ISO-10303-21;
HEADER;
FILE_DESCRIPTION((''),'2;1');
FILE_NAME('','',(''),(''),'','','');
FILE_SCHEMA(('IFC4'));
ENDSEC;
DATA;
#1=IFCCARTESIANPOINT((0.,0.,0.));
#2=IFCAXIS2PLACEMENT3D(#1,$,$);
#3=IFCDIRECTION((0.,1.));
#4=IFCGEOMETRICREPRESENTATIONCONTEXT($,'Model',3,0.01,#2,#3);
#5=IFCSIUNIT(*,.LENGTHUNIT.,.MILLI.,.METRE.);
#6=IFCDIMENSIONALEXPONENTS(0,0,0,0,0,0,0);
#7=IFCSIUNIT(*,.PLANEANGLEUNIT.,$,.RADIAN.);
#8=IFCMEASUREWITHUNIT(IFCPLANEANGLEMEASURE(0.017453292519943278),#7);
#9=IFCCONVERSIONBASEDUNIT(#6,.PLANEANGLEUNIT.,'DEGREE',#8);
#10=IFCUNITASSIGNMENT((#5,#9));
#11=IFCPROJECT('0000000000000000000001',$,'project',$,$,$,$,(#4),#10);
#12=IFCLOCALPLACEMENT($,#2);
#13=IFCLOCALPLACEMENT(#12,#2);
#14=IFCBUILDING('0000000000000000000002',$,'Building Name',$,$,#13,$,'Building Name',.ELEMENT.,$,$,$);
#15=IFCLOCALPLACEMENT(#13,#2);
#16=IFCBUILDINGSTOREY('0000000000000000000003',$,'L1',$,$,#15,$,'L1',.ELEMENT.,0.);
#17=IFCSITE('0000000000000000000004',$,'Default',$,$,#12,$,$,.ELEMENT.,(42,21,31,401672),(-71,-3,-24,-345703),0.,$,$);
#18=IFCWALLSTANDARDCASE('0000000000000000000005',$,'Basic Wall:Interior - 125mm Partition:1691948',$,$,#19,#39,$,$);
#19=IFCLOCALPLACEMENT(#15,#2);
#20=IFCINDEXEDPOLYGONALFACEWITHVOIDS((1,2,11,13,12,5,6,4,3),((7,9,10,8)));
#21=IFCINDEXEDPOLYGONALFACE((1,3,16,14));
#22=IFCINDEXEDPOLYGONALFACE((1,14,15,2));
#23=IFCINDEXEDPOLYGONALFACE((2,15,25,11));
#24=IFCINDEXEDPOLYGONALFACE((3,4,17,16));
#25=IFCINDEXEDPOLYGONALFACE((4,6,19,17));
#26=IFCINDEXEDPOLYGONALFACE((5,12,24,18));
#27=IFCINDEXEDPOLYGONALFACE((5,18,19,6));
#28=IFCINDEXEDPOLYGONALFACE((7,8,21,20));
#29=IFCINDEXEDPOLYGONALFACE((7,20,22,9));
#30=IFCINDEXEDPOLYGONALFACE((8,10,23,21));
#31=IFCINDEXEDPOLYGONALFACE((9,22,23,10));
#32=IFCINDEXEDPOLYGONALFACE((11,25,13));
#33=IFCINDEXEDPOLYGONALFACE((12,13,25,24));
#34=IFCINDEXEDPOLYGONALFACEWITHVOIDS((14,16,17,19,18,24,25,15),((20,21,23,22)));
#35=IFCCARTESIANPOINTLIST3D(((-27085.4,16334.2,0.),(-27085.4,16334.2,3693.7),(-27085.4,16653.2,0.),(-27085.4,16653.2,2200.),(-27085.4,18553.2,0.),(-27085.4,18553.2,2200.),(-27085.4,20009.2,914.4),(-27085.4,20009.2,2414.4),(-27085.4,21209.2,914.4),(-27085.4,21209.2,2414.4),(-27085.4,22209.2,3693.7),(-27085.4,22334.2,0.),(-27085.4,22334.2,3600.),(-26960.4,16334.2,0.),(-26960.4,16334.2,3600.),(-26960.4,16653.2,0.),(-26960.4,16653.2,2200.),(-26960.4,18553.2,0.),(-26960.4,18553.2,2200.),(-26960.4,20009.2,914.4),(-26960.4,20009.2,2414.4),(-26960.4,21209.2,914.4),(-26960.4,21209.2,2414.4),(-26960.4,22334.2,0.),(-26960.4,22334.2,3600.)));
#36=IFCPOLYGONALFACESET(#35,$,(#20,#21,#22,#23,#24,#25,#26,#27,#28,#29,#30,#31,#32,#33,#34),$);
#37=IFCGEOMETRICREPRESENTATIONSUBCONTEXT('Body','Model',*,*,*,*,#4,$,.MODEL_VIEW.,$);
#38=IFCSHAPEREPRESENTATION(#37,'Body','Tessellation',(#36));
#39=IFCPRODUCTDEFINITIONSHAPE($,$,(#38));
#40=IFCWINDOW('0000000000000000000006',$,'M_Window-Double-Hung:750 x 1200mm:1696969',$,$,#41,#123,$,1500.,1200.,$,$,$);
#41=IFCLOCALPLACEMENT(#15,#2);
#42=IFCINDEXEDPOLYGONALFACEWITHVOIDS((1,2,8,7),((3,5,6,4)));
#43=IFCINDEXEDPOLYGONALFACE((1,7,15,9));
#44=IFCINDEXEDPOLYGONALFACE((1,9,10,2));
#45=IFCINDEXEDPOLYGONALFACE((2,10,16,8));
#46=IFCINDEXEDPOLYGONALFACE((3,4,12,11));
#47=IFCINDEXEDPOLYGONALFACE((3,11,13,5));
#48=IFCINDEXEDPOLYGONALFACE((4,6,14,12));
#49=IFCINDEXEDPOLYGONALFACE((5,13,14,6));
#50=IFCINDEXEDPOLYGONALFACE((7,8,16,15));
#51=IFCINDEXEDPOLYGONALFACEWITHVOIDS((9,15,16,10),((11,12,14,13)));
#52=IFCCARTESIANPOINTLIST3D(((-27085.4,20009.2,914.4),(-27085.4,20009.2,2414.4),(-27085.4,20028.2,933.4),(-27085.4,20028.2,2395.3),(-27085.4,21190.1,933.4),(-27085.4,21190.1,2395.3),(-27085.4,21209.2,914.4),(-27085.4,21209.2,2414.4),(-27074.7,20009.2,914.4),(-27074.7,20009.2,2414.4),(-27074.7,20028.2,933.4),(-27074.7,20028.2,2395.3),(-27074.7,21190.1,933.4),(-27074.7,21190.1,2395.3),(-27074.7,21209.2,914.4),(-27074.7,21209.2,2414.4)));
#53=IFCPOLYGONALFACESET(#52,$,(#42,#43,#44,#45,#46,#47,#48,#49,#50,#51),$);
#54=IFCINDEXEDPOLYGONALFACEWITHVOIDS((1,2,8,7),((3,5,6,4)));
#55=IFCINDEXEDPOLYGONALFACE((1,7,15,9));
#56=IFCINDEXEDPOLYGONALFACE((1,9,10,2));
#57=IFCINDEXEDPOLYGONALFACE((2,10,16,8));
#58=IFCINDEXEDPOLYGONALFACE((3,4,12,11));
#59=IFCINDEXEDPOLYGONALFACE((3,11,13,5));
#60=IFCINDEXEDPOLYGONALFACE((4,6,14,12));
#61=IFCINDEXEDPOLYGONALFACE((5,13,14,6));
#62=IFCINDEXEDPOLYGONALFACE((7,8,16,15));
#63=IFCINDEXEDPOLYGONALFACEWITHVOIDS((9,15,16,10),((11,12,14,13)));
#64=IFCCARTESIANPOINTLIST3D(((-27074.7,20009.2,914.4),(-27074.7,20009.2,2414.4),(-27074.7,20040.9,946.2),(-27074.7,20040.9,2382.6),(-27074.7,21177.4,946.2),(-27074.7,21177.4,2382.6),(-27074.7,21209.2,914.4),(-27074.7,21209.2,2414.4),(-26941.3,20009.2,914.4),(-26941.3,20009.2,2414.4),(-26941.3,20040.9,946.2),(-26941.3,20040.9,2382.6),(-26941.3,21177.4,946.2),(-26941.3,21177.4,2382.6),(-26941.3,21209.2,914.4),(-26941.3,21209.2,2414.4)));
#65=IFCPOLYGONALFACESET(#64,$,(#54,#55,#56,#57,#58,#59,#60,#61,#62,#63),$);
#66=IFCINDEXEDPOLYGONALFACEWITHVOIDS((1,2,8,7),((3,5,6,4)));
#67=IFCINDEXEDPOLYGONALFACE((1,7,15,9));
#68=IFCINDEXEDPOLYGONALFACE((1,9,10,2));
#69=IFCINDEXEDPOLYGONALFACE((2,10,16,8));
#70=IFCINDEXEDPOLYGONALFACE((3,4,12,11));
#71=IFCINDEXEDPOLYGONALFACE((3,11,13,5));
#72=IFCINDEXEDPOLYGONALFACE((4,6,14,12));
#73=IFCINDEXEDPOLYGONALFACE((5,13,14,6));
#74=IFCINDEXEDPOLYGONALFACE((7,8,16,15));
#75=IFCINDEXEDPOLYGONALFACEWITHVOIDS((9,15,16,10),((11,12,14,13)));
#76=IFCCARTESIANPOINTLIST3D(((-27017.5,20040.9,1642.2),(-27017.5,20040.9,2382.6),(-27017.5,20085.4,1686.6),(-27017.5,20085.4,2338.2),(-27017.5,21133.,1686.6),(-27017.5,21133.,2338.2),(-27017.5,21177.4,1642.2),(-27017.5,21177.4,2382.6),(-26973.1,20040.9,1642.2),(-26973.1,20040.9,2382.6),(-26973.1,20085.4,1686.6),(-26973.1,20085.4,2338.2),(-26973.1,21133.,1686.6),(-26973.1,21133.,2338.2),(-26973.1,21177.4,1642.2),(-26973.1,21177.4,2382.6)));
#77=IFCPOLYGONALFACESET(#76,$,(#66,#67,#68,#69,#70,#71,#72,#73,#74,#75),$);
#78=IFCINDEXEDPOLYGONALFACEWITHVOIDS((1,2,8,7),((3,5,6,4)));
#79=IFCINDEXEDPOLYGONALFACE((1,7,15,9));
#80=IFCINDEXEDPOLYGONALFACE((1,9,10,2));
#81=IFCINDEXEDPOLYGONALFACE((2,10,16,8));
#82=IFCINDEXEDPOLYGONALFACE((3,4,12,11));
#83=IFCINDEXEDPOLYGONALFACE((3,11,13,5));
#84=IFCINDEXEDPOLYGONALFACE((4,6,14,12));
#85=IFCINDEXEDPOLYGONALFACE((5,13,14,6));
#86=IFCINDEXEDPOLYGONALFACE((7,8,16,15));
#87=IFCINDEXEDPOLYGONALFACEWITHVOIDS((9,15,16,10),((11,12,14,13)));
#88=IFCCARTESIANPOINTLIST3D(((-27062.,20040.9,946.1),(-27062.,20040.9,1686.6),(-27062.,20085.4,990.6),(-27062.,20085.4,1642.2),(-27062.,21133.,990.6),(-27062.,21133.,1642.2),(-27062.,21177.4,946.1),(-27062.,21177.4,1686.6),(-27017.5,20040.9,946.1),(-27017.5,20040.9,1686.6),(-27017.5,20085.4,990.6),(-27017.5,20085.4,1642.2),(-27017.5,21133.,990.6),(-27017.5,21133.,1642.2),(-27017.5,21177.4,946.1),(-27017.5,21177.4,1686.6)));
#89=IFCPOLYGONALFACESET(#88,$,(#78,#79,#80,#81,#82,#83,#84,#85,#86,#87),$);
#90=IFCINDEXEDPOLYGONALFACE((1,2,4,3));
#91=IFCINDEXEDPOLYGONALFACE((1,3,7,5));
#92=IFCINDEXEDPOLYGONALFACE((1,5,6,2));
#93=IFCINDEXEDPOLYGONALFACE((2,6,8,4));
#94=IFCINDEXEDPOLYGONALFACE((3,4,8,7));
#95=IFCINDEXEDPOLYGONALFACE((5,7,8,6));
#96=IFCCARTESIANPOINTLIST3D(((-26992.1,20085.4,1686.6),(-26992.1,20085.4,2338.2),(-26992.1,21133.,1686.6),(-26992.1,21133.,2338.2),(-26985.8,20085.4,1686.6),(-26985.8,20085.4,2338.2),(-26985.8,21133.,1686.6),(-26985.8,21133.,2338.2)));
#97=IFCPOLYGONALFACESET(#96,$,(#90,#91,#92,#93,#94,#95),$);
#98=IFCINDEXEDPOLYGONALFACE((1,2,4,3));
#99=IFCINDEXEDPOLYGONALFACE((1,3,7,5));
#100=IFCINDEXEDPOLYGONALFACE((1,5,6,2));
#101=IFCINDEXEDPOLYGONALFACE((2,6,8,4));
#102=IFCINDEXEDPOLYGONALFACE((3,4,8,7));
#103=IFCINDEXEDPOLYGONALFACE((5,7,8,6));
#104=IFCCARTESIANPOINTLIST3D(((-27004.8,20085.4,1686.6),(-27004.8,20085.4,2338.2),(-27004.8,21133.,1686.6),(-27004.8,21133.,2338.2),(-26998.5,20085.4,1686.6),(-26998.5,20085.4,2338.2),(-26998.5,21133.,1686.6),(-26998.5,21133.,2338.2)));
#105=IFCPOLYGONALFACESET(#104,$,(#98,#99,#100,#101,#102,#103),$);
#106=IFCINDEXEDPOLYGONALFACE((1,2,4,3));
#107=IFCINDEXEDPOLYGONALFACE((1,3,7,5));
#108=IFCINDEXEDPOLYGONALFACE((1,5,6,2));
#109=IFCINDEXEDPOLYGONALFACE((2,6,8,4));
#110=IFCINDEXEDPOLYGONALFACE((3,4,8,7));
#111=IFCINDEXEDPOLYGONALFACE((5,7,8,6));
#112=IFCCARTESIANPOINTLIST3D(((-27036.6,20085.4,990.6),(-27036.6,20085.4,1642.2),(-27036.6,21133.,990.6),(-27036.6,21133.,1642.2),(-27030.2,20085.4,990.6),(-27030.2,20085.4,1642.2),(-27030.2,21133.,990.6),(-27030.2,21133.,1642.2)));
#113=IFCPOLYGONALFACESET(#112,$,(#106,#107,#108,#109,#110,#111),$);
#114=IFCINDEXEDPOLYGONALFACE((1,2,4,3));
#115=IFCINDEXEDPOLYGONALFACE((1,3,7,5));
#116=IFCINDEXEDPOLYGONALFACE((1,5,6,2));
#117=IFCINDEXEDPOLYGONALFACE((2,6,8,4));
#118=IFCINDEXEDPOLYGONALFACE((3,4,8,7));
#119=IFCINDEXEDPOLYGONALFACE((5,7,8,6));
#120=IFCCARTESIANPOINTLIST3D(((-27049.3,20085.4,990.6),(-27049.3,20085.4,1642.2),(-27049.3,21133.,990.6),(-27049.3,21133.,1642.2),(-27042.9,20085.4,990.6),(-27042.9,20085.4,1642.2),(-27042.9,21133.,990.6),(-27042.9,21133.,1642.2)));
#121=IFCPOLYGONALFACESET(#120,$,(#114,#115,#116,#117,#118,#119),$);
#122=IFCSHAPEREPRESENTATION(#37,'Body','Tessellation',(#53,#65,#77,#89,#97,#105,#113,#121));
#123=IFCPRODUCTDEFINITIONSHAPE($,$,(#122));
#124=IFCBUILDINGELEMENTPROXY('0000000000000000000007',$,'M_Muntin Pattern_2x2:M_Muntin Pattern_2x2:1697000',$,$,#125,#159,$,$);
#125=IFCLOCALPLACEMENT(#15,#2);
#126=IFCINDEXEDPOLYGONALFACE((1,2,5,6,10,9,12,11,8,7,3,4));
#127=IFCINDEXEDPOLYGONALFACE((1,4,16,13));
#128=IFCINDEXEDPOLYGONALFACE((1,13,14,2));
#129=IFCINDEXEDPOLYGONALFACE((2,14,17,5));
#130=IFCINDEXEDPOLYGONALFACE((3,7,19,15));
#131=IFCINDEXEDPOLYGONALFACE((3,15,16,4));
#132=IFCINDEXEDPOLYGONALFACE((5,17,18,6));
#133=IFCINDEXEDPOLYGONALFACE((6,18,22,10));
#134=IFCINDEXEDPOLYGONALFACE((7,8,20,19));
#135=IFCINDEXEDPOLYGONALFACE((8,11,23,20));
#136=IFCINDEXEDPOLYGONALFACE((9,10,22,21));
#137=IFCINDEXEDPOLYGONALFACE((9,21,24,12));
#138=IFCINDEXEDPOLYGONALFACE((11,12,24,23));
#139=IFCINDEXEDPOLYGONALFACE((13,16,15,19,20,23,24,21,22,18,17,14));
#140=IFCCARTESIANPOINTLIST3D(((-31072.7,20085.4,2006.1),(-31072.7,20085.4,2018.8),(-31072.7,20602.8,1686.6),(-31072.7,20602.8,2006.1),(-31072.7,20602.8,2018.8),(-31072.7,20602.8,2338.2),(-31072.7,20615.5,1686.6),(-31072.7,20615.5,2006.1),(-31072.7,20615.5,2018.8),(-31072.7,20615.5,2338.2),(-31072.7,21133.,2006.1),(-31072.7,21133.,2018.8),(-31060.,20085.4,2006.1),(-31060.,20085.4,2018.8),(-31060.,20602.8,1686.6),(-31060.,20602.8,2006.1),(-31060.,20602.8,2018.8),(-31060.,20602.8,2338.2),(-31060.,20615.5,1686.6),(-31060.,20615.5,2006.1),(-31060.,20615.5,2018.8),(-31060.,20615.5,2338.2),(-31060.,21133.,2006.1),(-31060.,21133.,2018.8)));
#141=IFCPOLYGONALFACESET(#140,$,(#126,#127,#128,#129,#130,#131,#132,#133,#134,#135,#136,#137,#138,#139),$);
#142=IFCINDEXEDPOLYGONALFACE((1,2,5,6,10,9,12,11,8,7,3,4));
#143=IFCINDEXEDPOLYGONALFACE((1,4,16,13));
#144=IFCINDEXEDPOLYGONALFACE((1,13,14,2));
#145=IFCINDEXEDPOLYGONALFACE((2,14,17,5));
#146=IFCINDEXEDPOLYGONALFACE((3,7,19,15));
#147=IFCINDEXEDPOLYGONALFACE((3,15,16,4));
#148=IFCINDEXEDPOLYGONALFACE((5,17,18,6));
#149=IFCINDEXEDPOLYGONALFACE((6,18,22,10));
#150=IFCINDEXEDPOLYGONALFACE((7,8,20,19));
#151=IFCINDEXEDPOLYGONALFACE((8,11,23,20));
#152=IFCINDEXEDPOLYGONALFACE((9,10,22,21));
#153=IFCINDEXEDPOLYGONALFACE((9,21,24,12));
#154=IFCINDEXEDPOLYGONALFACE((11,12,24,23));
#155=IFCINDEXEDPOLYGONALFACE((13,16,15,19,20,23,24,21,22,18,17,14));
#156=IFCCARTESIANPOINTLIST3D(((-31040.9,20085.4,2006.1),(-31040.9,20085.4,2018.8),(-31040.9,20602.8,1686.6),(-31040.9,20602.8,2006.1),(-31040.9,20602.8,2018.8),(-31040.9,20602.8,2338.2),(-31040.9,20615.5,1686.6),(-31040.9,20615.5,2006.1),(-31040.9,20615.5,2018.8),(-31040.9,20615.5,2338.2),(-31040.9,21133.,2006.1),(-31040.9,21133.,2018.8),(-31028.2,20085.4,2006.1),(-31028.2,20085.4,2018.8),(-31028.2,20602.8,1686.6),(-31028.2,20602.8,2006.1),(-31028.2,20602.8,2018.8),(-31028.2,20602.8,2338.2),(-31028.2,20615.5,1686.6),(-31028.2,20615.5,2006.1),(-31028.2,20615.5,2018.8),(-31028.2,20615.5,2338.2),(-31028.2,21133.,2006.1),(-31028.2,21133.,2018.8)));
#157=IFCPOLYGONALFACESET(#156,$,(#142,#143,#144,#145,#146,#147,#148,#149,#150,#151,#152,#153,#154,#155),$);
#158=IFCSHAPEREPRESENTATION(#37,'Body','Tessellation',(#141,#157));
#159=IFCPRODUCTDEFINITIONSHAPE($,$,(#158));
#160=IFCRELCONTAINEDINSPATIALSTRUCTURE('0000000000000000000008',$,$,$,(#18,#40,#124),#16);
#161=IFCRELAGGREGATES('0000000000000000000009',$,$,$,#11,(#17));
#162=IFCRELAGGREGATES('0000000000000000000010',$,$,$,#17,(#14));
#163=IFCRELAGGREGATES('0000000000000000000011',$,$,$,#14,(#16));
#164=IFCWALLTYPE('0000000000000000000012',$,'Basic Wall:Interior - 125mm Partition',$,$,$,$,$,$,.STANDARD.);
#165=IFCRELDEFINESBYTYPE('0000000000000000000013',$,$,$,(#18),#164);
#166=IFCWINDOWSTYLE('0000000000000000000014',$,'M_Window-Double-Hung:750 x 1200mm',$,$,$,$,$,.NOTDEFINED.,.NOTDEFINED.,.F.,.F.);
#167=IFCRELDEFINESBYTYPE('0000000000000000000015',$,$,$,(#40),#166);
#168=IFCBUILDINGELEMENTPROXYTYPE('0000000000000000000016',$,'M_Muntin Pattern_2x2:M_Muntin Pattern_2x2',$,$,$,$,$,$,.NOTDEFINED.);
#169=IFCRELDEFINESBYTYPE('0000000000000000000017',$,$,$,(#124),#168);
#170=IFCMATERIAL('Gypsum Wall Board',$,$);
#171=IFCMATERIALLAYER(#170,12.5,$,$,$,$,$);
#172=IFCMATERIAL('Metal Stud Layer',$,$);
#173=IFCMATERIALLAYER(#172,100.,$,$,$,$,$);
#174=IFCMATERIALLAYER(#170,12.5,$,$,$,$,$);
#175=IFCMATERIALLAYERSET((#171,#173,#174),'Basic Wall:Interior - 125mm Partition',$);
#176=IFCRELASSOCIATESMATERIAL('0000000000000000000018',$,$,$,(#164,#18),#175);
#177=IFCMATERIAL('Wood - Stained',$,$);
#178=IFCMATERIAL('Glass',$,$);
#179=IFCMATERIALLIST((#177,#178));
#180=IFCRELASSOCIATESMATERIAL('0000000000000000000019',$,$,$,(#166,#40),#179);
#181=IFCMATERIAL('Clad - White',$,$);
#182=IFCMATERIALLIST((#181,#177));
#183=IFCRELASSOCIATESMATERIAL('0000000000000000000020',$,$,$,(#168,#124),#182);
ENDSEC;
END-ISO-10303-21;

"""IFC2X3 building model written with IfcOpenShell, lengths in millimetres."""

from ifc_helpers import new_model, entity, si_unit, converted_unit, direction, frame, frame_2d, origin, place, context, subcontext, project, spatial, polyline, rectangle, outline, extrude, clip, bounded_halfspace, source, transform, mapped, material, material_list, layer, layer_set, layer_usage, type_object, type_shapes, element, fill, save


model = new_model("IFC2X3")

# Units and contexts
model_context = context("Model", 3, precision=0.01, world=origin(), true_north=direction((0.0, 1.0)))
body_context = subcontext(model_context, "Body", "Model", "MODEL_VIEW")
ifc_project = project(units=[si_unit("LENGTHUNIT", "METRE", prefix="MILLI"), converted_unit("PLANEANGLEUNIT", "DEGREE", entity("IfcPlaneAngleMeasure", 0.017453292519943278), si_unit("PLANEANGLEUNIT", "RADIAN"), dimensions=[0, 0, 0, 0, 0, 0, 0])], contexts=[model_context])

# Site, building, storey
site_placement = place(None, origin())
site = spatial("IfcSite", under=ifc_project, at=site_placement, Name="Default", CompositionType="ELEMENT", RefLatitude=(42, 21, 31, 401672), RefLongitude=(-71, -3, -24, -345703), RefElevation=0.0)
building_placement = place(site_placement, origin())
building = spatial("IfcBuilding", under=site, at=building_placement, Name="Building Name", LongName="Building Name", CompositionType="ELEMENT")
storey_placement = place(building_placement, origin())
storey = spatial("IfcBuildingStorey", under=building, at=storey_placement, Name="L1", LongName="L1", CompositionType="ELEMENT", Elevation=0.0)

# Shared definitions
ifc_material_1 = material(Name="Gypsum Wall Board")
ifc_layer_1 = layer(ifc_material_1, 12.5)
ifc_material_2 = material(Name="Metal Stud Layer")
ifc_layer_2 = layer(ifc_material_2, 100.0)
ifc_layer_3 = layer(ifc_material_1, 12.5)
ifc_layer_set = layer_set([ifc_layer_1, ifc_layer_2, ifc_layer_3], Name="Basic Wall:Interior - 125mm Partition")
wall_type = type_object("IfcWallType", Name="Basic Wall:Interior - 125mm Partition", PredefinedType="STANDARD", material=ifc_layer_set)
ifc_material_3 = material(Name="Wood - Stained")
ifc_material_4 = material(Name="Glass")
ifc_material_list_1 = material_list([ifc_material_3, ifc_material_4])

# Wall, openings, window
ifc_layer_usage_1 = layer_usage(ifc_layer_set, "AXIS2", "NEGATIVE", 62.5)
wall_1_placement = place(storey_placement, frame((-27022.9, 22334.2, 0.0), z_axis=(0.0, 0.0, 1.0), x_axis=(0.0, -1.0, 0.0)))
wall_1 = element("IfcWallStandardCase", 1, at=wall_1_placement, inside=storey, type_object=wall_type, material=ifc_layer_usage_1, Name="Basic Wall:Interior - 125mm Partition:1691948", context=body_context, shape_type="Clipping", body=[
    clip(clip(extrude(rectangle(XDim=125.0, YDim=6000.0, at=frame_2d((3000.0, 0.0), x_axis=(0.0, 1.0))), origin(), (0.0, 0.0, 1.0), 3693.8), bounded_halfspace(frame((0.0, 62.5, 3600.0), z_axis=(-0.6, 0.0, 0.8), x_axis=(0.0, -1.0, 0.0)), False, frame((0.0, 62.5, 3600.0)), polyline([(0.0, 0.0), (0.0, -125.0), (125.0, -125.0), (0.0, 0.0)]))), bounded_halfspace(frame((6000.0, 62.5, 3600.0), z_axis=(0.0, 0.6, 0.8), x_axis=(-1.0, 0.0, 0.0)), False, frame((6000.0, 62.5, 3600.0)), polyline([(0.0, 0.0), (-6000.0, 0.0), (-5875.0, -125.0), (0.0, -125.0), (0.0, 0.0)]))),
])
opening_1_placement = place(wall_1_placement, frame((3781.0, -62.5, 0.0)))
element("IfcOpeningElement", 2, at=opening_1_placement, cuts=wall_1, ObjectType="Opening", context=body_context, shape_type="SweptSolid", body=[
    extrude(rectangle(XDim=2200.0, YDim=1900.0, at=frame_2d((1100.0, 950.0), x_axis=(1.0, 0.0))), frame((0.0, 0.0, 0.0), z_axis=(0.0, 1.0, 0.0), x_axis=(0.0, 0.0, 1.0)), (0.0, 0.0, 1.0), 125.0),
])
opening_2_placement = place(wall_1_placement, frame((1125.0, -62.5, 914.4)))
opening_2 = element("IfcOpeningElement", 3, at=opening_2_placement, cuts=wall_1, ObjectType="Opening", context=body_context, shape_type="SweptSolid", body=[
    extrude(rectangle(XDim=1500.0, YDim=1200.0, at=frame_2d((750.0, 600.0), x_axis=(-1.0, 0.0))), frame((0.0, 0.0, 0.0), z_axis=(0.0, 1.0, 0.0), x_axis=(0.0, 0.0, 1.0)), (0.0, 0.0, 1.0), 125.0),
])
window_style_1 = type_object("IfcWindowStyle", Name="M_Window-Double-Hung:750 x 1200mm", ConstructionType="NOTDEFINED", OperationType="NOTDEFINED", ParameterTakesPrecedence=False, Sizeable=False, material=ifc_material_list_1)
shared_shape_1 = source(origin(), body_context, "Body", "SweptSolid", [
    extrude(outline(polyline([(-750.0, -600.0), (750.0, -600.0), (750.0, 600.0), (-750.0, 600.0), (-750.0, -600.0)]), holes=[polyline([(-730.9, -580.9), (-730.9, 580.9), (730.9, 580.9), (730.9, -580.9), (-730.9, -580.9)])]), frame((600.0, 10.7, 750.0), z_axis=(0.0, -1.0, 0.0), x_axis=(0.0, 0.0, -1.0)), (0.0, 0.0, 1.0), 10.7),
    extrude(outline(polyline([(-750.0, -600.0), (750.0, -600.0), (750.0, 600.0), (-750.0, 600.0), (-750.0, -600.0)]), holes=[polyline([(-718.2, 568.2), (718.2, 568.2), (718.2, -568.2), (-718.2, -568.2), (-718.2, 568.2)])]), frame((600.0, 144.0, 750.0), z_axis=(0.0, -1.0, 0.0), x_axis=(0.0, 0.0, -1.0)), (0.0, 0.0, 1.0), 133.3),
    extrude(outline(polyline([(-370.2, -568.2), (370.2, -568.2), (370.2, 568.2), (-370.2, 568.2), (-370.2, -568.2)]), holes=[polyline([(-325.8, 523.8), (325.8, 523.8), (325.8, -523.8), (-325.8, -523.8), (-325.8, 523.8)])]), frame((600.0, 112.3, 1098.0), z_axis=(0.0, -1.0, 0.0), x_axis=(0.0, 0.0, -1.0)), (0.0, 0.0, 1.0), 44.4),
    extrude(outline(polyline([(-370.2, -568.2), (370.2, -568.2), (370.2, 568.2), (-370.2, 568.2), (-370.2, -568.2)]), holes=[polyline([(-325.8, 523.8), (325.8, 523.8), (325.8, -523.8), (-325.8, -523.8), (-325.8, 523.8)])]), frame((600.0, 67.8, 402.0), z_axis=(0.0, -1.0, 0.0), x_axis=(0.0, 0.0, -1.0)), (0.0, 0.0, 1.0), 44.5),
    extrude(rectangle(XDim=6.3, YDim=1047.6, at=frame_2d((0.0, 0.0), x_axis=(1.0, 0.0))), frame((600.0, 96.4, 772.2), z_axis=(0.0, 0.0, 1.0), x_axis=(0.0, -1.0, 0.0)), (0.0, 0.0, 1.0), 651.6),
    extrude(rectangle(XDim=1047.6, YDim=6.4, at=frame_2d((0.0, 0.0), x_axis=(1.0, 0.0))), frame((600.0, 83.7, 772.2), z_axis=(0.0, 0.0, 1.0), x_axis=(-1.0, 0.0, 0.0)), (0.0, 0.0, 1.0), 651.6),
    extrude(rectangle(XDim=6.4, YDim=1047.6, at=frame_2d((0.0, 0.0), x_axis=(1.0, 0.0))), frame((600.0, 52.0, 76.2), z_axis=(0.0, 0.0, 1.0), x_axis=(0.0, -1.0, 0.0)), (0.0, 0.0, 1.0), 651.6),
    extrude(rectangle(XDim=1047.6, YDim=6.3, at=frame_2d((0.0, 0.0), x_axis=(1.0, 0.0))), frame((600.0, 39.3, 76.2), z_axis=(0.0, 0.0, 1.0), x_axis=(-1.0, 0.0, 0.0)), (0.0, 0.0, 1.0), 651.6),
])
type_shapes(window_style_1, [shared_shape_1])
window_1_placement = place(opening_2_placement, origin())
window_1 = element("IfcWindow", 4, at=window_1_placement, inside=storey, type_object=window_style_1, material=ifc_material_list_1, Name="M_Window-Double-Hung:750 x 1200mm:1696969", OverallHeight=1500.0, OverallWidth=1200.0, context=body_context, shape_type="MappedRepresentation", body=[
    mapped(shared_shape_1, transform((0.0, 0.0, 0.0), scale=1.0)),
])
fill(opening_2, window_1)

# Building element proxy
ifc_material_5 = material(Name="Clad - White")
ifc_material_list_2 = material_list([ifc_material_5, ifc_material_3])
building_element_proxy_type_1 = type_object("IfcBuildingElementProxyType", Name="M_Muntin Pattern_2x2:M_Muntin Pattern_2x2", PredefinedType="NOTDEFINED", material=ifc_material_list_2)
shared_shape_2 = source(origin(), body_context, "Body", "SweptSolid", [
    extrude(outline(polyline([(6.4, -6.4), (325.8, -6.4), (325.8, 6.3), (6.4, 6.3), (6.4, 523.8), (-6.3, 523.8), (-6.3, 6.3), (-325.8, 6.3), (-325.8, -6.4), (-6.3, -6.4), (-6.3, -523.8), (6.4, -523.8), (6.4, -6.4)])), frame((0.0, 9.5, 325.8), z_axis=(0.0, 1.0, 0.0), x_axis=(0.0, 0.0, 1.0)), (0.0, 0.0, 1.0), 12.7),
    extrude(outline(polyline([(6.4, -6.4), (325.8, -6.4), (325.8, 6.3), (6.4, 6.3), (6.4, 523.8), (-6.3, 523.8), (-6.3, 6.3), (-325.8, 6.3), (-325.8, -6.4), (-6.3, -6.4), (-6.3, -523.8), (6.4, -523.8), (6.4, -6.4)])), frame((0.0, -22.2, 325.8), z_axis=(0.0, 1.0, 0.0), x_axis=(0.0, 0.0, 1.0)), (0.0, 0.0, 1.0), 12.7),
])
type_shapes(building_element_proxy_type_1, [shared_shape_2])
for number, where, z_axis, x_axis, name in (
    (5, (-31050.4, 20609.2, 1686.6), (0.0, 0.0, 1.0), (0.0, 1.0, 0.0), "M_Muntin Pattern_2x2:M_Muntin Pattern_2x2:1697000"),
):
    element("IfcBuildingElementProxy", number, at=place(storey_placement, frame(where, z_axis=z_axis, x_axis=x_axis)), inside=storey, type_object=building_element_proxy_type_1, material=ifc_material_list_2, Name=name, context=body_context, shape_type="MappedRepresentation", body=[
        mapped(shared_shape_2, transform((0.0, 0.0, 0.0), scale=1.0)),
    ])

save(model, "model.ifc")
